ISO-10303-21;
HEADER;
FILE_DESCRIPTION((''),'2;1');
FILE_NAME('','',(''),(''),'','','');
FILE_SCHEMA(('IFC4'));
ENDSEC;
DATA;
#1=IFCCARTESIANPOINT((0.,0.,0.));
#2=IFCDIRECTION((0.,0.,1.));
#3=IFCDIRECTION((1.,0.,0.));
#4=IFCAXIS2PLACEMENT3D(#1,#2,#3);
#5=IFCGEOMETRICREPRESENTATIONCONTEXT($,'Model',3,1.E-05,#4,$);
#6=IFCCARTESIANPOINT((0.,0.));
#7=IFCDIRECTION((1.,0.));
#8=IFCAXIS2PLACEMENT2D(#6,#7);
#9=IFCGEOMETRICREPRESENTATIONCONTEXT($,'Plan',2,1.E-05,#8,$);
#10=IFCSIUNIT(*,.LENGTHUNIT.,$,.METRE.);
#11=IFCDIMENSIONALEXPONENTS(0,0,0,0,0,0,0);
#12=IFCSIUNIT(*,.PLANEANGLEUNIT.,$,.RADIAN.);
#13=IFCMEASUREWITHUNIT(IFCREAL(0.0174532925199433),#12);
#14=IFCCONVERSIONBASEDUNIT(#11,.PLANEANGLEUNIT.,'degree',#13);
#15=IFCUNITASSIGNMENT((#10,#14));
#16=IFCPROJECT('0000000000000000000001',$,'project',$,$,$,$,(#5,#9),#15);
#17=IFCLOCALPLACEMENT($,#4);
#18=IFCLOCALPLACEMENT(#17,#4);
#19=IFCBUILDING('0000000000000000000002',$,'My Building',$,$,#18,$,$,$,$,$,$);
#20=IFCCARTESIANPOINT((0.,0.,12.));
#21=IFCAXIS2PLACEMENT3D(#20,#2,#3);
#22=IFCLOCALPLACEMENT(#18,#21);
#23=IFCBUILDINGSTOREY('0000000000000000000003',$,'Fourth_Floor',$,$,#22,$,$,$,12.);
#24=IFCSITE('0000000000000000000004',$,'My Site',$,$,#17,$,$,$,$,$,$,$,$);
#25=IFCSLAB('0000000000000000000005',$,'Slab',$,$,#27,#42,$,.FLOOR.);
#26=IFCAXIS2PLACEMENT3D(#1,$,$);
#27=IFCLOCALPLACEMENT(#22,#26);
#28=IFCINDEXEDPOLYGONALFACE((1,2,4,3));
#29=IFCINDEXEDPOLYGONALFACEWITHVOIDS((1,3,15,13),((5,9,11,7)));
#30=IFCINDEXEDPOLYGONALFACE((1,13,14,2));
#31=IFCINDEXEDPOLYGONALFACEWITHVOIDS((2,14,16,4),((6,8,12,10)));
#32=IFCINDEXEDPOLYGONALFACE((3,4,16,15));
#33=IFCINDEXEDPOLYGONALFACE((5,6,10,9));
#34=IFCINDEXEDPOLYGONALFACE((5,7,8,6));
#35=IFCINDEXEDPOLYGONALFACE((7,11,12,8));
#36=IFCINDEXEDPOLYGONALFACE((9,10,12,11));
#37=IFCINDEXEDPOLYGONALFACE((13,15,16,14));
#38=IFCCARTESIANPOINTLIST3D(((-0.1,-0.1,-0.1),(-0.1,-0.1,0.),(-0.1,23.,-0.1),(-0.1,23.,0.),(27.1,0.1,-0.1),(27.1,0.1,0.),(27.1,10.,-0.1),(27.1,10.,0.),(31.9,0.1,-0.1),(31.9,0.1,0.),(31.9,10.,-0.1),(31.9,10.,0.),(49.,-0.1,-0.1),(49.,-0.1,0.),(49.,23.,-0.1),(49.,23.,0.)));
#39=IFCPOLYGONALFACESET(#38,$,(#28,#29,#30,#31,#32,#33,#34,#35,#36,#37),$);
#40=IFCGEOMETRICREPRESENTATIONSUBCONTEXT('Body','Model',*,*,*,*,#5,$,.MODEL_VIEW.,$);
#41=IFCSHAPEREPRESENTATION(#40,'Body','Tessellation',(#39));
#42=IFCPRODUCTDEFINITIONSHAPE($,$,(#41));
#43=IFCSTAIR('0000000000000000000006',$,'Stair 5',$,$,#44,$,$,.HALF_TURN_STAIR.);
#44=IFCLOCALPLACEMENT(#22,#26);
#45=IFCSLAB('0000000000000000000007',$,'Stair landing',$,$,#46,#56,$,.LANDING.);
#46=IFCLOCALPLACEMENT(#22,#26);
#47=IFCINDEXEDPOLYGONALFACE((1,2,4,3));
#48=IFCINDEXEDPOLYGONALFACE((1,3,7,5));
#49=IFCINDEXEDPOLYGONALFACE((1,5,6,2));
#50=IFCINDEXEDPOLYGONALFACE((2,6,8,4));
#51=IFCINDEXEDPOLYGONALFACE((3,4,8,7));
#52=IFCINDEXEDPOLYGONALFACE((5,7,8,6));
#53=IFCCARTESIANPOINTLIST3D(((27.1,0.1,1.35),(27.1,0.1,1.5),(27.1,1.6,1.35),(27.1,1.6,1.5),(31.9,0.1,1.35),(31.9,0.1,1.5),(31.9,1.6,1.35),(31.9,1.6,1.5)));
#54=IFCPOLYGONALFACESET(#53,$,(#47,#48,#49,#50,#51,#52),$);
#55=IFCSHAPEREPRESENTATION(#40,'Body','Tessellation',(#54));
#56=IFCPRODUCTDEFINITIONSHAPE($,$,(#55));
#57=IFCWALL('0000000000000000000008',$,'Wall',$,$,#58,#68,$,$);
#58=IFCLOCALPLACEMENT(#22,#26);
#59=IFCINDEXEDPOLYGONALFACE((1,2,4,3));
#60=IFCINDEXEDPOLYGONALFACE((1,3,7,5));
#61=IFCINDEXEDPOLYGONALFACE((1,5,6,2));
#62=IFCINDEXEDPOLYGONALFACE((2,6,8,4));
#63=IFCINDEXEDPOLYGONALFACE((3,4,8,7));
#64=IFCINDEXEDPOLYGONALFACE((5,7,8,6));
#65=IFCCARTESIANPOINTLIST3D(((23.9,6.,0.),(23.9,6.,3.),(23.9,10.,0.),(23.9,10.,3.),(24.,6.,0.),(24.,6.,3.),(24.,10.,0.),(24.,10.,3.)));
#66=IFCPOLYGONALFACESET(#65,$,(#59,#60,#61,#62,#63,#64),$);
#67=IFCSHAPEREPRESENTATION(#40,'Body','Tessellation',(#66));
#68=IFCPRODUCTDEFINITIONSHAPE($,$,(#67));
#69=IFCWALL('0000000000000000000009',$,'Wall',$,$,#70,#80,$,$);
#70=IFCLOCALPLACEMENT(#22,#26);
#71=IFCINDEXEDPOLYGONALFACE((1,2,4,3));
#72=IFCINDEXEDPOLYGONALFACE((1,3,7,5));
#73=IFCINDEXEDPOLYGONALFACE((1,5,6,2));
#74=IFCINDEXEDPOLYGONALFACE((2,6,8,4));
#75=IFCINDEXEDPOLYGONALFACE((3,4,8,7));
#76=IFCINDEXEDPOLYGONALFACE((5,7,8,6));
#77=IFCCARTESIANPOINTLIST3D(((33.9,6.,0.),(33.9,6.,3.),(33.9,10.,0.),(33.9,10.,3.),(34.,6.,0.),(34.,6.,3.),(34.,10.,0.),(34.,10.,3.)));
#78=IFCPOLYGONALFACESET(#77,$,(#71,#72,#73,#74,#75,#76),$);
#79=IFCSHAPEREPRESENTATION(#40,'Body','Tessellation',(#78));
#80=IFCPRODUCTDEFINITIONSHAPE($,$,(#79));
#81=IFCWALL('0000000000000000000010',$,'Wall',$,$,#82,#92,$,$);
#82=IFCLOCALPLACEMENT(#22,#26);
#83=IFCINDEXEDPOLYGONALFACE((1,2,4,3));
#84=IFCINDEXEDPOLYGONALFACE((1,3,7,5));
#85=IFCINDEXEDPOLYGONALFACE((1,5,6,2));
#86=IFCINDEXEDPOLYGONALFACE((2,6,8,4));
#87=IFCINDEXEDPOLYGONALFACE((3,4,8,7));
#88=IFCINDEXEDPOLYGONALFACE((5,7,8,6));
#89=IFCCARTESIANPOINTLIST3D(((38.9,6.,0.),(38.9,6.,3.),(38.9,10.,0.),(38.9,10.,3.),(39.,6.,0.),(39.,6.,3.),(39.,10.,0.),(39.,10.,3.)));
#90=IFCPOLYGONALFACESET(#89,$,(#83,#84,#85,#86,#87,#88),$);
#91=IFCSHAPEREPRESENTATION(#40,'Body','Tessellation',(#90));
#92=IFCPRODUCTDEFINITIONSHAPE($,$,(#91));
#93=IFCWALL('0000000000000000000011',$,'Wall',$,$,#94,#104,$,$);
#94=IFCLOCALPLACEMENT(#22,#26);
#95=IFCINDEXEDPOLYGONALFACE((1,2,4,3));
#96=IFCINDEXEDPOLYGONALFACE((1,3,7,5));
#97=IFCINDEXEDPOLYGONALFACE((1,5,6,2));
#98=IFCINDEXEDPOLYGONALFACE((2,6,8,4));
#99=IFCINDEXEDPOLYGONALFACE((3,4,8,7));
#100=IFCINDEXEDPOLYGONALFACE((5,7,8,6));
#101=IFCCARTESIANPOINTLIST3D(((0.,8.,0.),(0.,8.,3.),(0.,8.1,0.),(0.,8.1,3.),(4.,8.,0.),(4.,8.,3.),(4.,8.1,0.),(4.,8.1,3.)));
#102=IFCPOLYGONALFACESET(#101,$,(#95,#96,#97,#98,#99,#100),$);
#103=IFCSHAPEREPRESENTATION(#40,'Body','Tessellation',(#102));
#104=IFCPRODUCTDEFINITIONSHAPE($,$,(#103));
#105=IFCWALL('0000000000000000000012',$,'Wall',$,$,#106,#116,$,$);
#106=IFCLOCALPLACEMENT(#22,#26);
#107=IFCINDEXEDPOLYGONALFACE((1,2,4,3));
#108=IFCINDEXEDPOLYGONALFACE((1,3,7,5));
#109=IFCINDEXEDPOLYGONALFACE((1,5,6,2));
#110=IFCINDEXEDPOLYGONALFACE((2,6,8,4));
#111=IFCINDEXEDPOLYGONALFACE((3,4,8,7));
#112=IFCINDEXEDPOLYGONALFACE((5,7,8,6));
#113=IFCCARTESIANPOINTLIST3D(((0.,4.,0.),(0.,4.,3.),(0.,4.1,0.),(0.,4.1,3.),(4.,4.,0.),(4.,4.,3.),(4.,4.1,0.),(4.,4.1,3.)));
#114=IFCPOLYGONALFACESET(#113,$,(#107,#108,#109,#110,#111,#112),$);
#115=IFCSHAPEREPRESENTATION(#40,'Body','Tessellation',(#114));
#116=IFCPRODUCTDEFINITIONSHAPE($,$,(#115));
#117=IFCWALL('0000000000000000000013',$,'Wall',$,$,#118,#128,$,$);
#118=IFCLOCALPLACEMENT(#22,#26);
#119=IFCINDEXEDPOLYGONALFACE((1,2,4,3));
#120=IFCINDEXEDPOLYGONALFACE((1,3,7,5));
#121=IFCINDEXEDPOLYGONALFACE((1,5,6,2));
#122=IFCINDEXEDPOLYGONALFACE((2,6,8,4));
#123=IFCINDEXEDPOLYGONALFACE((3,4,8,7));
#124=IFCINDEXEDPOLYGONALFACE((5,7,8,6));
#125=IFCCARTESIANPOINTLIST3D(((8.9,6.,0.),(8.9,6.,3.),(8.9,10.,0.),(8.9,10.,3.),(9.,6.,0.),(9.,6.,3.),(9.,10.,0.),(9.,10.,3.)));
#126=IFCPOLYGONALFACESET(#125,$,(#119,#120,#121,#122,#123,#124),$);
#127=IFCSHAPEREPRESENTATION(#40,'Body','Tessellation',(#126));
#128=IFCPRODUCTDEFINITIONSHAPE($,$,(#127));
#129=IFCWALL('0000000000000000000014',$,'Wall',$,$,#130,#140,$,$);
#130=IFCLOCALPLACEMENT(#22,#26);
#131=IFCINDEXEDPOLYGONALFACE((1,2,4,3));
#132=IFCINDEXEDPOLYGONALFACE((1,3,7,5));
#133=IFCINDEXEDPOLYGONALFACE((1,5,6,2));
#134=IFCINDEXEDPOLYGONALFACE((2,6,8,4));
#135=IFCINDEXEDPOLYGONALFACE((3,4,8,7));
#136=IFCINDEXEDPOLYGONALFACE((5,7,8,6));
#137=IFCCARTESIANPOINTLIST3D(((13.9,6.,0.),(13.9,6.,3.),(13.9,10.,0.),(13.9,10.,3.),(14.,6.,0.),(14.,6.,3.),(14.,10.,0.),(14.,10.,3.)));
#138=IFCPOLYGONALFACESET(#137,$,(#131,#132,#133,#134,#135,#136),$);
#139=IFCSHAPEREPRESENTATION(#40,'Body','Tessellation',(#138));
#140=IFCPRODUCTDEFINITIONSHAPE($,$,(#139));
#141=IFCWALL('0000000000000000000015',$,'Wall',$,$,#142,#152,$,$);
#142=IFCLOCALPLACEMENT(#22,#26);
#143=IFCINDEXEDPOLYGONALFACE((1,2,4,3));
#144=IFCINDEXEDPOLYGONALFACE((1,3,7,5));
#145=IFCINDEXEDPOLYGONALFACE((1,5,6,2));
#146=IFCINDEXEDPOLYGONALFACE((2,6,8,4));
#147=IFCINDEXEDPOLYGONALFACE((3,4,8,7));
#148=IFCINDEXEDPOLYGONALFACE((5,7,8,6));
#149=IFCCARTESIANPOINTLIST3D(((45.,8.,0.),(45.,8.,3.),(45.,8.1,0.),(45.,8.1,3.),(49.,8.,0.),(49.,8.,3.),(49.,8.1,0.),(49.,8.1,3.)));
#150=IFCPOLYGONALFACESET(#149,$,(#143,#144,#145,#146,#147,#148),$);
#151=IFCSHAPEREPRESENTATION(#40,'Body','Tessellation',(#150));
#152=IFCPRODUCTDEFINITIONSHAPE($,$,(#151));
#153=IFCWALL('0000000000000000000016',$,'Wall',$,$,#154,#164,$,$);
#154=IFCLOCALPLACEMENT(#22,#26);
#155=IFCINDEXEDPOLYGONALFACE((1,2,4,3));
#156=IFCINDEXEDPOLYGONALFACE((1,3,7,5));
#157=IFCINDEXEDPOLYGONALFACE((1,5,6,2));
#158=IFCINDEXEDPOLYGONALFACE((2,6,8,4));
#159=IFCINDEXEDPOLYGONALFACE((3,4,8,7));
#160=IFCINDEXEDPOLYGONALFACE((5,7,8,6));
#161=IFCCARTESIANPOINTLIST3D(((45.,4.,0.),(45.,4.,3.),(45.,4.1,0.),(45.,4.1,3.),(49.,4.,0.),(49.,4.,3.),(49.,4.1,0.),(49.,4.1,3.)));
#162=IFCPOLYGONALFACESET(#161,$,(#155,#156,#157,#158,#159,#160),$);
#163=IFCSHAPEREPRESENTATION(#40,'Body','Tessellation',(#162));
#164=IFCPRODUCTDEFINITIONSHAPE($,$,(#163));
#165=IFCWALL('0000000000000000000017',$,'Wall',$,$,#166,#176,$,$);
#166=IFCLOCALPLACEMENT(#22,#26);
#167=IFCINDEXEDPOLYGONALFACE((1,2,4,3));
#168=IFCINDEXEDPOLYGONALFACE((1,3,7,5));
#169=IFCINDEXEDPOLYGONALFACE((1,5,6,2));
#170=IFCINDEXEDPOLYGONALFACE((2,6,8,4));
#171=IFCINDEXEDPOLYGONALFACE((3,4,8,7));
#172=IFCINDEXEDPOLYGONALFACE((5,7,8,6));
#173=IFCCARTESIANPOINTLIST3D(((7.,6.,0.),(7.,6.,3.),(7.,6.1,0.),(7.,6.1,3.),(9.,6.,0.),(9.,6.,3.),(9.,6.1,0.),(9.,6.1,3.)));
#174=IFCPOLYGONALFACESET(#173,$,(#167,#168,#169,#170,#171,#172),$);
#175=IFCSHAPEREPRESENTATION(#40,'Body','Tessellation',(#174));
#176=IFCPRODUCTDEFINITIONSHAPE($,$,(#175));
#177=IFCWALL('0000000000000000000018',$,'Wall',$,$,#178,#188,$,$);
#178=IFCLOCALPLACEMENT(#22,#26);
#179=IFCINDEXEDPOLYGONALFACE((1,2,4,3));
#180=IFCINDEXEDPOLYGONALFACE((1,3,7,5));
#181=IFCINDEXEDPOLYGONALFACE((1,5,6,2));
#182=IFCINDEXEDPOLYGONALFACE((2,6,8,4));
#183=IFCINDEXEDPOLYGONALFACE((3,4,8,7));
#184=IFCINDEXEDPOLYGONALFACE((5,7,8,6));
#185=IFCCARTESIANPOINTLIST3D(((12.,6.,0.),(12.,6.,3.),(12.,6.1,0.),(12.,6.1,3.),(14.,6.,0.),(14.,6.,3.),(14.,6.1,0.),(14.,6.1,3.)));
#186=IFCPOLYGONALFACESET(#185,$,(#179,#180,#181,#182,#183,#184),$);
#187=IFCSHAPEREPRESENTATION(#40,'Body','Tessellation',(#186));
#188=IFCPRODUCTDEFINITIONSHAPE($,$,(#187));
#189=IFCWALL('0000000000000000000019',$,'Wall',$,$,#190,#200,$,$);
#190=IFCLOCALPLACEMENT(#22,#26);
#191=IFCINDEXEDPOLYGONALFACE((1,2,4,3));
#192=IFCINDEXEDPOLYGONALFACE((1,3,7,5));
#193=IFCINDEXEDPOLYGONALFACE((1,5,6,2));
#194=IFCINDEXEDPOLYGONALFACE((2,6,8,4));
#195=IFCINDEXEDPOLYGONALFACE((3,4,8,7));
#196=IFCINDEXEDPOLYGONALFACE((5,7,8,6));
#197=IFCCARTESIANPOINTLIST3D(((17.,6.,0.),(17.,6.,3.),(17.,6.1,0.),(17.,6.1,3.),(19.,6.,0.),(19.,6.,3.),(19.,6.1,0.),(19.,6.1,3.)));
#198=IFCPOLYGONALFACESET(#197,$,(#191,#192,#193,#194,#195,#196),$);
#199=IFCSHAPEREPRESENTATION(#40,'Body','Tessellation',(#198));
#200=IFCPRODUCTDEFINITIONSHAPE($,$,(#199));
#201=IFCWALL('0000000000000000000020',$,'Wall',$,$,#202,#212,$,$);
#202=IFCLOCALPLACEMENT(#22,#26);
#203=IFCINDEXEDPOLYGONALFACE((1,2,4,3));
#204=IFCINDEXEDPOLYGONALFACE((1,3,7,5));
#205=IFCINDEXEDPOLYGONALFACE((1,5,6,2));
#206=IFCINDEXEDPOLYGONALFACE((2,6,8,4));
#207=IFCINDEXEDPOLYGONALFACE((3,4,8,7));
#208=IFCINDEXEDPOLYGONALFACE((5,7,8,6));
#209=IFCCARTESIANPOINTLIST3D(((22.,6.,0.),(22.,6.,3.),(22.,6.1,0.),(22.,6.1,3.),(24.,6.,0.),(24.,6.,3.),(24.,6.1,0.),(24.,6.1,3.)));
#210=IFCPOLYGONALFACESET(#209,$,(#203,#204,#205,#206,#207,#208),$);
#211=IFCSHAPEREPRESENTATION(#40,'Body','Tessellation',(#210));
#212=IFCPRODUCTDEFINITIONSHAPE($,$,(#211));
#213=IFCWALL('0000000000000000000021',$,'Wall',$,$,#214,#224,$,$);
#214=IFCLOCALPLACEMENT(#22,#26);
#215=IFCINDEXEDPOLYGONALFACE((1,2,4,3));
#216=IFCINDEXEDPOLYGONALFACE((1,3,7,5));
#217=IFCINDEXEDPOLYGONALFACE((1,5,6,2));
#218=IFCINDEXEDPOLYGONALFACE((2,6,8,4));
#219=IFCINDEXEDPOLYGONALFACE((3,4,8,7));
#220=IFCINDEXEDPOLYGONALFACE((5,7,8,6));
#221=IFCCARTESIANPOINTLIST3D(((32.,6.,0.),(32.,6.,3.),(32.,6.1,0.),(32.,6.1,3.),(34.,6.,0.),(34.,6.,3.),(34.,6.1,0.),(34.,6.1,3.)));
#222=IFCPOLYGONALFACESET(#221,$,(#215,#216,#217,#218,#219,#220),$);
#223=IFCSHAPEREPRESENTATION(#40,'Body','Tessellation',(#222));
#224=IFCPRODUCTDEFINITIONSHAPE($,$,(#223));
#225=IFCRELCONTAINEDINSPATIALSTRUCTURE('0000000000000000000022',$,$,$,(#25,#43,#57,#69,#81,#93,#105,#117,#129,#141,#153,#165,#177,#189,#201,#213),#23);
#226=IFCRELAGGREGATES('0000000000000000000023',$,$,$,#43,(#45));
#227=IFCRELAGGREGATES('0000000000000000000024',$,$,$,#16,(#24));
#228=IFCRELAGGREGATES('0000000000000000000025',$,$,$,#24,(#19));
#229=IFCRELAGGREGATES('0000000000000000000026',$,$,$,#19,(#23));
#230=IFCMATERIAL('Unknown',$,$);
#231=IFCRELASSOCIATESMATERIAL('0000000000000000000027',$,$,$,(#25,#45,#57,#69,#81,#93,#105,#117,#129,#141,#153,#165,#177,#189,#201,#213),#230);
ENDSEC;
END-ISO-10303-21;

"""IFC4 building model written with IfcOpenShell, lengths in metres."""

from ifc_helpers import new_model, entity, si_unit, converted_unit, frame, frame_2d, origin, origin_with_axes, origin_2d_with_axis, place, context, subcontext, project, spatial, rectangle, extrude, material, element, aggregate, save


model = new_model("IFC4")

# Units and contexts
model_context = context("Model", 3, precision=1e-05, world=origin_with_axes())
plan_context = context("Plan", 2, precision=1e-05, world=origin_2d_with_axis())
body_context = subcontext(model_context, "Body", "Model", "MODEL_VIEW")
ifc_project = project(units=[si_unit("LENGTHUNIT", "METRE"), converted_unit("PLANEANGLEUNIT", "degree", entity("IfcReal", 0.0174532925199433), si_unit("PLANEANGLEUNIT", "RADIAN"), dimensions=[0, 0, 0, 0, 0, 0, 0])], contexts=[model_context, plan_context])

# Site, building, storey
site_placement = place(None, origin_with_axes())
site = spatial("IfcSite", under=ifc_project, at=site_placement, Name="My Site")
building_placement = place(site_placement, origin_with_axes())
building = spatial("IfcBuilding", under=site, at=building_placement, Name="My Building")
storey_placement = place(building_placement, frame((0.0, 0.0, 12.0), z_axis=(0.0, 0.0, 1.0), x_axis=(1.0, 0.0, 0.0)))
storey = spatial("IfcBuildingStorey", under=building, at=storey_placement, Name="Fourth_Floor", Elevation=12.0)

# Slab, opening
ifc_material = material(Name="Unknown")
slab_1_placement = place(storey_placement, origin_with_axes())
slab_1 = element("IfcSlab", 1, at=slab_1_placement, inside=storey, material=ifc_material, Name="Slab", PredefinedType="FLOOR", context=body_context, shape_type="SweptSolid", body=[
    extrude(rectangle(XDim=49.1, YDim=23.1, at=frame_2d((24.45, 11.45))), frame((0.0, 0.0, -0.1)), (0.0, 0.0, 1.0), 0.1),
])
opening_placement = place(slab_1_placement, origin_with_axes())
element("IfcOpeningElement", 2, at=opening_placement, cuts=slab_1, context=body_context, shape_type="SweptSolid", body=[
    extrude(rectangle(XDim=4.8, YDim=9.9, at=frame_2d((29.5, 5.05))), frame((0.0, 0.0, -0.25)), (0.0, 0.0, 1.0), 0.4),
])

# Stair, slab
stair_placement = place(storey_placement, origin_with_axes())
stair = element("IfcStair", 3, at=stair_placement, inside=storey, Name="Stair 5", PredefinedType="HALF_TURN_STAIR")
slab_2_placement = place(stair_placement, origin_with_axes())
slab_2 = element("IfcSlab", 4, at=slab_2_placement, material=ifc_material, Name="Stair landing", PredefinedType="LANDING", context=body_context, shape_type="SweptSolid", body=[
    extrude(rectangle(XDim=4.8, YDim=1.5, at=frame_2d((29.5, 0.85))), frame((0.0, 0.0, 1.35)), (0.0, 0.0, 1.0), 0.15),
])

# Walls
wall_1_placement = place(storey_placement, origin_with_axes())
element("IfcWall", 5, at=wall_1_placement, inside=storey, material=ifc_material, Name="Wall", context=body_context, shape_type="SweptSolid", body=[
    extrude(rectangle(XDim=0.1, YDim=4.0, at=frame_2d((23.95, 8.0))), origin(), (0.0, 0.0, 1.0), 3.0),
])
wall_2_placement = place(storey_placement, origin_with_axes())
element("IfcWall", 6, at=wall_2_placement, inside=storey, material=ifc_material, Name="Wall", context=body_context, shape_type="SweptSolid", body=[
    extrude(rectangle(XDim=0.1, YDim=4.0, at=frame_2d((33.95, 8.0))), origin(), (0.0, 0.0, 1.0), 3.0),
])
wall_3_placement = place(storey_placement, origin_with_axes())
element("IfcWall", 7, at=wall_3_placement, inside=storey, material=ifc_material, Name="Wall", context=body_context, shape_type="SweptSolid", body=[
    extrude(rectangle(XDim=0.1, YDim=4.0, at=frame_2d((38.95, 8.0))), origin(), (0.0, 0.0, 1.0), 3.0),
])
wall_4_placement = place(storey_placement, origin_with_axes())
element("IfcWall", 8, at=wall_4_placement, inside=storey, material=ifc_material, Name="Wall", context=body_context, shape_type="SweptSolid", body=[
    extrude(rectangle(XDim=4.0, YDim=0.1, at=frame_2d((2.0, 8.05))), origin(), (0.0, 0.0, 1.0), 3.0),
])
wall_5_placement = place(storey_placement, origin_with_axes())
element("IfcWall", 9, at=wall_5_placement, inside=storey, material=ifc_material, Name="Wall", context=body_context, shape_type="SweptSolid", body=[
    extrude(rectangle(XDim=4.0, YDim=0.1, at=frame_2d((2.0, 4.05))), origin(), (0.0, 0.0, 1.0), 3.0),
])
wall_6_placement = place(storey_placement, origin_with_axes())
element("IfcWall", 10, at=wall_6_placement, inside=storey, material=ifc_material, Name="Wall", context=body_context, shape_type="SweptSolid", body=[
    extrude(rectangle(XDim=0.1, YDim=4.0, at=frame_2d((8.95, 8.0))), origin(), (0.0, 0.0, 1.0), 3.0),
])
wall_7_placement = place(storey_placement, origin_with_axes())
element("IfcWall", 11, at=wall_7_placement, inside=storey, material=ifc_material, Name="Wall", context=body_context, shape_type="SweptSolid", body=[
    extrude(rectangle(XDim=0.1, YDim=4.0, at=frame_2d((13.95, 8.0))), origin(), (0.0, 0.0, 1.0), 3.0),
])
wall_8_placement = place(storey_placement, origin_with_axes())
element("IfcWall", 12, at=wall_8_placement, inside=storey, material=ifc_material, Name="Wall", context=body_context, shape_type="SweptSolid", body=[
    extrude(rectangle(XDim=4.0, YDim=0.1, at=frame_2d((47.0, 8.05))), origin(), (0.0, 0.0, 1.0), 3.0),
])
wall_9_placement = place(storey_placement, origin_with_axes())
element("IfcWall", 13, at=wall_9_placement, inside=storey, material=ifc_material, Name="Wall", context=body_context, shape_type="SweptSolid", body=[
    extrude(rectangle(XDim=4.0, YDim=0.1, at=frame_2d((47.0, 4.05))), origin(), (0.0, 0.0, 1.0), 3.0),
])
wall_10_placement = place(storey_placement, origin_with_axes())
element("IfcWall", 14, at=wall_10_placement, inside=storey, material=ifc_material, Name="Wall", context=body_context, shape_type="SweptSolid", body=[
    extrude(rectangle(XDim=2.0, YDim=0.1, at=frame_2d((8.0, 6.05))), origin(), (0.0, 0.0, 1.0), 3.0),
])
wall_11_placement = place(storey_placement, origin_with_axes())
element("IfcWall", 15, at=wall_11_placement, inside=storey, material=ifc_material, Name="Wall", context=body_context, shape_type="SweptSolid", body=[
    extrude(rectangle(XDim=2.0, YDim=0.1, at=frame_2d((13.0, 6.05))), origin(), (0.0, 0.0, 1.0), 3.0),
])
wall_12_placement = place(storey_placement, origin_with_axes())
element("IfcWall", 16, at=wall_12_placement, inside=storey, material=ifc_material, Name="Wall", context=body_context, shape_type="SweptSolid", body=[
    extrude(rectangle(XDim=2.0, YDim=0.1, at=frame_2d((18.0, 6.05))), origin(), (0.0, 0.0, 1.0), 3.0),
])
wall_13_placement = place(storey_placement, origin_with_axes())
element("IfcWall", 17, at=wall_13_placement, inside=storey, material=ifc_material, Name="Wall", context=body_context, shape_type="SweptSolid", body=[
    extrude(rectangle(XDim=2.0, YDim=0.1, at=frame_2d((23.0, 6.05))), origin(), (0.0, 0.0, 1.0), 3.0),
])
wall_14_placement = place(storey_placement, origin_with_axes())
element("IfcWall", 18, at=wall_14_placement, inside=storey, material=ifc_material, Name="Wall", context=body_context, shape_type="SweptSolid", body=[
    extrude(rectangle(XDim=2.0, YDim=0.1, at=frame_2d((33.0, 6.05))), origin(), (0.0, 0.0, 1.0), 3.0),
])

aggregate(stair, [slab_2])

save(model, "model.ifc")
